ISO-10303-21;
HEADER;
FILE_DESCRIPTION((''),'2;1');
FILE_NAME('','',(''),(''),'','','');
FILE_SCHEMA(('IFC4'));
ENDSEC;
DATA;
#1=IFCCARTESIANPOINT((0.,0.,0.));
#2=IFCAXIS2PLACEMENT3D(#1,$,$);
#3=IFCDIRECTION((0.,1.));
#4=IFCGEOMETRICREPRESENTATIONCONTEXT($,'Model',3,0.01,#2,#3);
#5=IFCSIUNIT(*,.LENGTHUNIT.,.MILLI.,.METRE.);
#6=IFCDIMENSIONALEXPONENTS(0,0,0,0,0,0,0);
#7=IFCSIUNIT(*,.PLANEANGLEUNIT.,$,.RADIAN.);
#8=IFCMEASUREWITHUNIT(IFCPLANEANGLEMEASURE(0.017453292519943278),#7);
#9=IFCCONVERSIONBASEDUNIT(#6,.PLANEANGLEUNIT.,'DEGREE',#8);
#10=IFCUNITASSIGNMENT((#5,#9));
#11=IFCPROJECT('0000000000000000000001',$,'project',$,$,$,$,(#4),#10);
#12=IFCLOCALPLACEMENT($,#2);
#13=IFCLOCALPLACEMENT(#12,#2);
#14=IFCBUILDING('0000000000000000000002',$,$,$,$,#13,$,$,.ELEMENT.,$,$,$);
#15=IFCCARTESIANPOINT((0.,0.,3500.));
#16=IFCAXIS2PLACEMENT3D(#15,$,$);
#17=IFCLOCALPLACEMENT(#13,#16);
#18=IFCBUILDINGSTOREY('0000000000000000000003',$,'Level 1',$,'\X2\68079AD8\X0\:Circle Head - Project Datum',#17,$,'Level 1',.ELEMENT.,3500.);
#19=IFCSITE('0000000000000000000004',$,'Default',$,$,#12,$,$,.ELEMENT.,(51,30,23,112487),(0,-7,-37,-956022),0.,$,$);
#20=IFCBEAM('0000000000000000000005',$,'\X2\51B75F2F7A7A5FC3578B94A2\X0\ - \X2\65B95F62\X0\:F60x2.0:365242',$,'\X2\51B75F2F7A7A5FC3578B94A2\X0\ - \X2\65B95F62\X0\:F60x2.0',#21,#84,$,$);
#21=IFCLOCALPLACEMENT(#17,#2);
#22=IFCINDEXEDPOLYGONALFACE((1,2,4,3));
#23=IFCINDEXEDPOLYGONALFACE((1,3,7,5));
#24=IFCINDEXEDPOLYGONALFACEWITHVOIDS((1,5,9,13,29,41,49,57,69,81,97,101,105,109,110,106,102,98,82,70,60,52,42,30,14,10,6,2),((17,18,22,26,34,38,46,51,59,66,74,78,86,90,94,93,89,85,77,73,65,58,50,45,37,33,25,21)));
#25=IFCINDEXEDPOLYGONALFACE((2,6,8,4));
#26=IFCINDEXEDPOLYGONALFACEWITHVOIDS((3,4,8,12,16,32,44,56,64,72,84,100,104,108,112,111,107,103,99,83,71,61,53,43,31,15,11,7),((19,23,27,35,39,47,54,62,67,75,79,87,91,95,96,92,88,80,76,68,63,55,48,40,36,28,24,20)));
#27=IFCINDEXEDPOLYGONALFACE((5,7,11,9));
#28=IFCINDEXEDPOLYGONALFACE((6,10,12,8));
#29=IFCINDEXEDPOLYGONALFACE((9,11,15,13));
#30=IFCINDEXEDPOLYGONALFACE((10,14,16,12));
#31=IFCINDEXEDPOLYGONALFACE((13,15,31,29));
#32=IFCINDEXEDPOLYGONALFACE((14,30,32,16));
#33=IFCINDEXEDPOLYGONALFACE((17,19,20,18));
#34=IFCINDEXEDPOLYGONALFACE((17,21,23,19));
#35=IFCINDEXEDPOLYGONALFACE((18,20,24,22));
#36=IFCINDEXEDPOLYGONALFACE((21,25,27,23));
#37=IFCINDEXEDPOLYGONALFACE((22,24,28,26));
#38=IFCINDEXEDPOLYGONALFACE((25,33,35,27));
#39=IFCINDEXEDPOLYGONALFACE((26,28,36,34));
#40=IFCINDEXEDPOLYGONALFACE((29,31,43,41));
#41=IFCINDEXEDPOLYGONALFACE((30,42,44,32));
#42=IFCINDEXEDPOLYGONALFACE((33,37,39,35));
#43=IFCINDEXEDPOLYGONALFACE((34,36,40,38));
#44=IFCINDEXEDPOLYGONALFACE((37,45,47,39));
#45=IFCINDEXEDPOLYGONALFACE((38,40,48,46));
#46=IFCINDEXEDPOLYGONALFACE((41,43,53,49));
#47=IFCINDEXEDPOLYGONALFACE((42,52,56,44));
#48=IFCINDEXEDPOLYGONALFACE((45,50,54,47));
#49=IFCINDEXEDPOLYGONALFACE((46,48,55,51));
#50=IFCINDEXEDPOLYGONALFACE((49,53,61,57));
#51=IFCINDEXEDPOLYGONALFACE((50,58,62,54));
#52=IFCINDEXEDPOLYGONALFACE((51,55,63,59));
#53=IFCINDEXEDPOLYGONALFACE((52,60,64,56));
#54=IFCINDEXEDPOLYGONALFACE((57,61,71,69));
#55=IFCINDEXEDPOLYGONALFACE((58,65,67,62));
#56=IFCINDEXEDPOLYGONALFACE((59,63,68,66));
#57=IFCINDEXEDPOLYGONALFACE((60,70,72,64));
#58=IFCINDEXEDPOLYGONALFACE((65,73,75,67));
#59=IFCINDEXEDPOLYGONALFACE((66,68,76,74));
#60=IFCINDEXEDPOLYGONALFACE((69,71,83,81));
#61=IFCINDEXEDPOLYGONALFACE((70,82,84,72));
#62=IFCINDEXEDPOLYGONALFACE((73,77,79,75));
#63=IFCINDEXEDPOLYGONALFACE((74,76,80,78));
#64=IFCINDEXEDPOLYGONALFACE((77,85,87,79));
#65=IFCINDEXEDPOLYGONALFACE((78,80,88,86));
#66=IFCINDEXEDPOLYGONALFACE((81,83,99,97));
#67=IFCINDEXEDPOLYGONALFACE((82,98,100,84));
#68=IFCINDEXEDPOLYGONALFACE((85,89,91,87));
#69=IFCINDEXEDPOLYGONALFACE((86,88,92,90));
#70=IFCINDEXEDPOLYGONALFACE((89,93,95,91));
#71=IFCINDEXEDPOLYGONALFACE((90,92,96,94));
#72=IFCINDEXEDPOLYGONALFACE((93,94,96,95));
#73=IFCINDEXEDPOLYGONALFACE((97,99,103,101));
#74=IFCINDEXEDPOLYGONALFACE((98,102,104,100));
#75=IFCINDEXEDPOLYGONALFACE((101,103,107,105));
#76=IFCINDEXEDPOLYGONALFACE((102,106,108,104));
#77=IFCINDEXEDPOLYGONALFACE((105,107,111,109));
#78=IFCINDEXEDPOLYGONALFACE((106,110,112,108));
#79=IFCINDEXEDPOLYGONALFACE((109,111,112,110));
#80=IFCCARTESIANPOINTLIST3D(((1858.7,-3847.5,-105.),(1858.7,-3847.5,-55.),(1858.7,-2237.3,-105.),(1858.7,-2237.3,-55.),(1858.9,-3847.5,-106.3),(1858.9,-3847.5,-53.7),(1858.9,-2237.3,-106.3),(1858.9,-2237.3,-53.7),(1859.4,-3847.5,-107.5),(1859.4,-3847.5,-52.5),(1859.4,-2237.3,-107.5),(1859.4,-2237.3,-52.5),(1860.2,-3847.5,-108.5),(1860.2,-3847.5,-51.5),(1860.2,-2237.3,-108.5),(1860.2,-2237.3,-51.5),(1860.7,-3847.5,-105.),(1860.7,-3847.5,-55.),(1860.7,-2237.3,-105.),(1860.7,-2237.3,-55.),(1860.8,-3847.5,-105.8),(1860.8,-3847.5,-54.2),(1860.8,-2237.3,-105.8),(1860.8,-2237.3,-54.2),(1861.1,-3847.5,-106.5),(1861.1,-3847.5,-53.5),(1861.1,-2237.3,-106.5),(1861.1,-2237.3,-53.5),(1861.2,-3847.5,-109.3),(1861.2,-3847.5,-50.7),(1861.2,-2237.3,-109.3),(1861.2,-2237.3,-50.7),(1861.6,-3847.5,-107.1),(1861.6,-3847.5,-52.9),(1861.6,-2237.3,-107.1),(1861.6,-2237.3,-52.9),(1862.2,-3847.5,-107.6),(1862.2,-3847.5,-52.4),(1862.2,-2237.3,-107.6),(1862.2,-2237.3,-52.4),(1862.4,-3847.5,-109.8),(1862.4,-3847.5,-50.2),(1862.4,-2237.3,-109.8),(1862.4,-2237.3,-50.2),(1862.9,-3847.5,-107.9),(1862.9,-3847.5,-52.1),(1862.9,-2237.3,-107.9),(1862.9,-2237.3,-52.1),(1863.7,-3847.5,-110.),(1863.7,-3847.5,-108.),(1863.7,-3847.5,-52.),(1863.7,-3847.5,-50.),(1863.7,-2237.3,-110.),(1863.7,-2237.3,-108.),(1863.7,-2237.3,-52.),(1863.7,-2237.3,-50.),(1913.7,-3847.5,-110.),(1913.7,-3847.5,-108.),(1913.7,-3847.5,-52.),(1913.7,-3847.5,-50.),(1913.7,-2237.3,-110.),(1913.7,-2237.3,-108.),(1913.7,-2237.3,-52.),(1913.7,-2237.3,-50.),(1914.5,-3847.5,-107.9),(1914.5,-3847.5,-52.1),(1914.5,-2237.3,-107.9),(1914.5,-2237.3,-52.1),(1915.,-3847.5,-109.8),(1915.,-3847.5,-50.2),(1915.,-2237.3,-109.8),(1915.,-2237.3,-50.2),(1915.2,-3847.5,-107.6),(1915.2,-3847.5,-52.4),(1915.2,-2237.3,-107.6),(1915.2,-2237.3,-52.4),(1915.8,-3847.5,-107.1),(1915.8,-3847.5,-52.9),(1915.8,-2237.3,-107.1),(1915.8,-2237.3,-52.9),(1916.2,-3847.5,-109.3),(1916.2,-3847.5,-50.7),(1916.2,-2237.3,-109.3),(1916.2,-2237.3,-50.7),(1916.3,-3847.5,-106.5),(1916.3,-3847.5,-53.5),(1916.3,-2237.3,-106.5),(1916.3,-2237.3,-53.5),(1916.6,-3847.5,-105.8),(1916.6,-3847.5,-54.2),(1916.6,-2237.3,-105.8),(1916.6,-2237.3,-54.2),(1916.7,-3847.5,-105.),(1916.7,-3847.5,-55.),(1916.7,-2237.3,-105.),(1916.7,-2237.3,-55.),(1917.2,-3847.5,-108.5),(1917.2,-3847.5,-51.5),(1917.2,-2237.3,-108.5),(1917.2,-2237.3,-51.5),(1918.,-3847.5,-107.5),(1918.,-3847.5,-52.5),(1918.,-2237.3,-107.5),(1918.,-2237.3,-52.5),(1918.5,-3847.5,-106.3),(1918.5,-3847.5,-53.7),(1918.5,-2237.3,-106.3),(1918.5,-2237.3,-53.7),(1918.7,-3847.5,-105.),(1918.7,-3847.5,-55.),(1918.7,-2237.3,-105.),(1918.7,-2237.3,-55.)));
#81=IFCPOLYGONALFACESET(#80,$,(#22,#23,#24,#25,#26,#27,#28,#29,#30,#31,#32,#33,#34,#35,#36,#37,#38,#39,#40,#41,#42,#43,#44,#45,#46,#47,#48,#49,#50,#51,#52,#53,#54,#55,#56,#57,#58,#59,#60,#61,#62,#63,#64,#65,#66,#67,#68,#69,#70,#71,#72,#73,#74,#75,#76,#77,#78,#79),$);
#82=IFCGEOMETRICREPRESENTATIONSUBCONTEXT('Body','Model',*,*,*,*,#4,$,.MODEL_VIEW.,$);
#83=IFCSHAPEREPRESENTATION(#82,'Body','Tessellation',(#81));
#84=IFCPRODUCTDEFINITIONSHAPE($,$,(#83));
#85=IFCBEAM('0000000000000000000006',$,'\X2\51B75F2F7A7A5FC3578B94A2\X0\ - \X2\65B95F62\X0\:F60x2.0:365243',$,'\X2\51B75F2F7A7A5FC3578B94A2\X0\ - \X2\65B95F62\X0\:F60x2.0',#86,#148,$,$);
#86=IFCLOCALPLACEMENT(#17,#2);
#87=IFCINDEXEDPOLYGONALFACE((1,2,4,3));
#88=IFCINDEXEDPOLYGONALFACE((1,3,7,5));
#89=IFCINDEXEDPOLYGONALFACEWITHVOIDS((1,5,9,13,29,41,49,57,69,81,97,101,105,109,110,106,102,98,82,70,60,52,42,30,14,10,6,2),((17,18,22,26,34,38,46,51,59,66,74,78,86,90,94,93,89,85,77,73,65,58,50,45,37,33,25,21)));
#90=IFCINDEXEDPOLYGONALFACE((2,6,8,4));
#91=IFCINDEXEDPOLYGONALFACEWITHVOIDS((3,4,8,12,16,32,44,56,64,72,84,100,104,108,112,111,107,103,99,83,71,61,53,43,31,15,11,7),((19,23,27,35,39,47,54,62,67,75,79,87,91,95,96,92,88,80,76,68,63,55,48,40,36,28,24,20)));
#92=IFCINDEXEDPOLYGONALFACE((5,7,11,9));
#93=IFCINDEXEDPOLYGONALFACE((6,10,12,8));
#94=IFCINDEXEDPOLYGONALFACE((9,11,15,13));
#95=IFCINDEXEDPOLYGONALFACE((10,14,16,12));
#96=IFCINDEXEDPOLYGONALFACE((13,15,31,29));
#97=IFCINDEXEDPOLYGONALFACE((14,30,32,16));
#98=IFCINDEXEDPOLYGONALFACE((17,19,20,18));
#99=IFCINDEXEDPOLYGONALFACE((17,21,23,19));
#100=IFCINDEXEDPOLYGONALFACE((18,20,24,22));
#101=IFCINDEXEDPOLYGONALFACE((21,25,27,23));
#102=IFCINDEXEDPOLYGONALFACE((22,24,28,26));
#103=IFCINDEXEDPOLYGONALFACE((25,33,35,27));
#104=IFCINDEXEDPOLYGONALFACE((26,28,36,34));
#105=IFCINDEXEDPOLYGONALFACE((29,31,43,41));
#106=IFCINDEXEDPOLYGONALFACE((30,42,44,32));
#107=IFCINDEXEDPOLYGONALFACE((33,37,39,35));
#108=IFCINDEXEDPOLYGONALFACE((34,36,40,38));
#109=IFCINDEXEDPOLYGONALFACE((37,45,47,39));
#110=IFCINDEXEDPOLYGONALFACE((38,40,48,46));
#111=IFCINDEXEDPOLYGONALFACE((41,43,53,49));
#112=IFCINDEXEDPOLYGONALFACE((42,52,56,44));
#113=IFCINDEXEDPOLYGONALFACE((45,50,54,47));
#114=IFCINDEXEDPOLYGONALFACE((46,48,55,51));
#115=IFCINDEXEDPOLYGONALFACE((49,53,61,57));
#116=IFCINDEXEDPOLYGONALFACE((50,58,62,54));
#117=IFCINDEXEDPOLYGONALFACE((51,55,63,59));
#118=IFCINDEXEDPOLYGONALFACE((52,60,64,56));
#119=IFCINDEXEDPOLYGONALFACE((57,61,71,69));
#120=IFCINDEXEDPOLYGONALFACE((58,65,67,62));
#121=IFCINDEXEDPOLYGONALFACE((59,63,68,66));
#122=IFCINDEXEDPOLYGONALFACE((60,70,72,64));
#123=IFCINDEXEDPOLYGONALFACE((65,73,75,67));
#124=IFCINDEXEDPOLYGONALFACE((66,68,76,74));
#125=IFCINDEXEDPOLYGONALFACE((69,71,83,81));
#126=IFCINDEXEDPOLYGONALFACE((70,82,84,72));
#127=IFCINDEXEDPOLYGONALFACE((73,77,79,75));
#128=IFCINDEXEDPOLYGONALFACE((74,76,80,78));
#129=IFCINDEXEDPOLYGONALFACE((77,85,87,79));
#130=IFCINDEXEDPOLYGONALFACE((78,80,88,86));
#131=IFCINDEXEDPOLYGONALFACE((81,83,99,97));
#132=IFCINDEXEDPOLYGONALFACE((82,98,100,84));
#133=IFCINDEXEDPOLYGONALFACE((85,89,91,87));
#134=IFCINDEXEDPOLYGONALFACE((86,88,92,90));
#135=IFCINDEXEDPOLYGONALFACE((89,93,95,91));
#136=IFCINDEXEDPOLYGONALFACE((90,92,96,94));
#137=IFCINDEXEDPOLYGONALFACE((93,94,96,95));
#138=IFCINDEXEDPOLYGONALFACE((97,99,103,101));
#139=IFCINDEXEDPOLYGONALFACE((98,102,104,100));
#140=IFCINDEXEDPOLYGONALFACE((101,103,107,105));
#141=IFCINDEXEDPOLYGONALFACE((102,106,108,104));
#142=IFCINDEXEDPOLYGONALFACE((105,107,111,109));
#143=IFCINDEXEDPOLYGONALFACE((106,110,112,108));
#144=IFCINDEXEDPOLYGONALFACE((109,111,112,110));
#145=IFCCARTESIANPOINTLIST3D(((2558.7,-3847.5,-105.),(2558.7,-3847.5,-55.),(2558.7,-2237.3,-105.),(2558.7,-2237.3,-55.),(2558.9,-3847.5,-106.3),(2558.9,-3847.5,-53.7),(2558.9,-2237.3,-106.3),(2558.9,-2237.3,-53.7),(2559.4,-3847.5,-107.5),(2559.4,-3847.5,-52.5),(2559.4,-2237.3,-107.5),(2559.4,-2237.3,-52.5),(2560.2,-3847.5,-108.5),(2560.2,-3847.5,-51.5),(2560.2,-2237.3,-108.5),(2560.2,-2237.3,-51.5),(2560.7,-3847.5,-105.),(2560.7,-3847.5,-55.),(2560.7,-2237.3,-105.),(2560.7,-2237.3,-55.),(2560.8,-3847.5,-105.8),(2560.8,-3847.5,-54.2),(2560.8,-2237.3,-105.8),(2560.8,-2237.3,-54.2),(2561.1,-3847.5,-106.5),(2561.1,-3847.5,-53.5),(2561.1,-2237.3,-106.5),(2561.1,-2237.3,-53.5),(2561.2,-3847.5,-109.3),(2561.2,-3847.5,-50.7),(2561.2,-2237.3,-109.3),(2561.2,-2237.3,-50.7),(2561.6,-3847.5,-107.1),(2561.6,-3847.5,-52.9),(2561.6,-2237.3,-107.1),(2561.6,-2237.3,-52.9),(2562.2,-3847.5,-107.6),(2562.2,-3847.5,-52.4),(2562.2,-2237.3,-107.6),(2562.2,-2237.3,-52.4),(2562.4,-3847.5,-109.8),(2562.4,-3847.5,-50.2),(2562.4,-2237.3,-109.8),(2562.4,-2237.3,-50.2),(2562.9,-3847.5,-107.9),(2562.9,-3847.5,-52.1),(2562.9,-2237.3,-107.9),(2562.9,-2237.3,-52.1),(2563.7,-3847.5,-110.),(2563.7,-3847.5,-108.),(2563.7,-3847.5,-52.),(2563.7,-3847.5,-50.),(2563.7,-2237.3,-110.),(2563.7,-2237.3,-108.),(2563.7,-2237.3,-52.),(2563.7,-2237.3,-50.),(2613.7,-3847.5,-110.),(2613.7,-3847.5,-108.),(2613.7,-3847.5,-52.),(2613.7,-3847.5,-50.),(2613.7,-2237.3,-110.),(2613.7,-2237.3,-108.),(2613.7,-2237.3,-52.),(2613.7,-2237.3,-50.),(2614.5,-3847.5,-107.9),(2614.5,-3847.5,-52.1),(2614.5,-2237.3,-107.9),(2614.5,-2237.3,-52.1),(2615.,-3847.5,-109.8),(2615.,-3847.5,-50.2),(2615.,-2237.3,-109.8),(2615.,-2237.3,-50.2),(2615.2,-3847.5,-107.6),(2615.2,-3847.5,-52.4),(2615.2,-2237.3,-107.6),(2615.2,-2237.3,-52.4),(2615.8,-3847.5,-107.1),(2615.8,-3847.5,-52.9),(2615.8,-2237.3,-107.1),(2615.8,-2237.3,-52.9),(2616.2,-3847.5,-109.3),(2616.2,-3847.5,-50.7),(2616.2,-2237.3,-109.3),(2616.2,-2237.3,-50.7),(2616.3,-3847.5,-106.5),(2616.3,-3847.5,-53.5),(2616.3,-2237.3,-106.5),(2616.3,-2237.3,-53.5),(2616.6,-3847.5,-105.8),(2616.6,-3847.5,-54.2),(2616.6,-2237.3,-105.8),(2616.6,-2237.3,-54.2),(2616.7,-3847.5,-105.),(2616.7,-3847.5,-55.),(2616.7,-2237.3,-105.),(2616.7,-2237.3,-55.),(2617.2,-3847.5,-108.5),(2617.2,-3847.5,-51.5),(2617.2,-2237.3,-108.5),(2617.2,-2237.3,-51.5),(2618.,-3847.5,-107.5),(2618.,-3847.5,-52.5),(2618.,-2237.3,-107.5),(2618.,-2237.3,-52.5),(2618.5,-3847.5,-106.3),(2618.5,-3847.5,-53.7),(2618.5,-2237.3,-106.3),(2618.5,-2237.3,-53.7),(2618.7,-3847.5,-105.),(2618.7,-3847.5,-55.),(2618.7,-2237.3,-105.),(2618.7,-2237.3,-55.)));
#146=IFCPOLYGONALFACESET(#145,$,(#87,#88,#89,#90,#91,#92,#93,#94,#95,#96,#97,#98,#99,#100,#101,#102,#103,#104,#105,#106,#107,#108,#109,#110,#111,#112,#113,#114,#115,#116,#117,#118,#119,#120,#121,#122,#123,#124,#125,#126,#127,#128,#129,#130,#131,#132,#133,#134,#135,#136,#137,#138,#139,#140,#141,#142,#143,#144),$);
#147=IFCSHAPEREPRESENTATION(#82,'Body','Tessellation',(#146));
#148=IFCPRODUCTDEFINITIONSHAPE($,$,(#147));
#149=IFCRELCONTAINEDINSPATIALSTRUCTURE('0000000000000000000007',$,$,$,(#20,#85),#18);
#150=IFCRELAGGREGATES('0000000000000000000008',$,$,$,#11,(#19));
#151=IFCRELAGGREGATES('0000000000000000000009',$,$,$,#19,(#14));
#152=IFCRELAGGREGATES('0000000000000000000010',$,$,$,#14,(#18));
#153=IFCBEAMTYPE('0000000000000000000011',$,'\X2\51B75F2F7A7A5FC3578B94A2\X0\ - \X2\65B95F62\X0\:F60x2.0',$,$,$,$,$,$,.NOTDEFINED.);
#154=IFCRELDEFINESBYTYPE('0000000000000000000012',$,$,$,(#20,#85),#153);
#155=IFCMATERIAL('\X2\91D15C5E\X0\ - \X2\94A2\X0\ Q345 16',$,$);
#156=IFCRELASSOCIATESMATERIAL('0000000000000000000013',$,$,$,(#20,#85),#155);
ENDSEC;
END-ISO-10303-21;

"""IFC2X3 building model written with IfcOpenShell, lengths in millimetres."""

from ifc_helpers import new_model, entity, si_unit, converted_unit, direction, frame, frame_2d, origin, place, context, subcontext, project, spatial, polyline, circle_curve, parameter, trimmed, segment, composite_curve, outline, extrude, material, type_object, element, save


model = new_model("IFC2X3")

# Units and contexts
model_context = context("Model", 3, precision=0.01, world=origin(), true_north=direction((0.0, 1.0)))
body_context = subcontext(model_context, "Body", "Model", "MODEL_VIEW")
ifc_project = project(units=[si_unit("LENGTHUNIT", "METRE", prefix="MILLI"), converted_unit("PLANEANGLEUNIT", "DEGREE", entity("IfcPlaneAngleMeasure", 0.017453292519943278), si_unit("PLANEANGLEUNIT", "RADIAN"), dimensions=[0, 0, 0, 0, 0, 0, 0])], contexts=[model_context])

# Site, building, storey
site_placement = place(None, origin())
site = spatial("IfcSite", under=ifc_project, at=site_placement, Name="Default", CompositionType="ELEMENT", RefLatitude=(51, 30, 23, 112487), RefLongitude=(0, -7, -37, -956022), RefElevation=0.0)
building_placement = place(site_placement, origin())
building = spatial("IfcBuilding", under=site, at=building_placement, CompositionType="ELEMENT")
storey_placement = place(building_placement, frame((0.0, 0.0, 3500.0)))
storey = spatial("IfcBuildingStorey", under=building, at=storey_placement, Name="Level 1", ObjectType="标高:Circle Head - Project Datum", LongName="Level 1", CompositionType="ELEMENT", Elevation=3500.0)

# Beams
ifc_material_1 = material(Name="金属 - 钢 Q345 16")
beam_type_1 = type_object("IfcBeamType", Name="冷弯空心型钢 - 方形:F60x2.0", PredefinedType="NOTDEFINED")
beam_1_placement = place(storey_placement, frame((1888.7, -3815.6, -50.0), z_axis=(0.0, 0.0, 1.0), x_axis=(0.0, 1.0, 0.0)))
element("IfcBeam", 1, at=beam_1_placement, inside=storey, type_object=beam_type_1, material=ifc_material_1, Name="冷弯空心型钢 - 方形:F60x2.0:365242", ObjectType="冷弯空心型钢 - 方形:F60x2.0", context=body_context, shape_type="SweptSolid", body=[
    extrude(outline(composite_curve([segment(polyline([(-25.0, -30.0), (25.0, -30.0)]), True, "CONTINUOUS"), segment(trimmed(circle_curve(frame_2d((25.0, -25.0), x_axis=(1.0, 0.0)), 5.0), [parameter(270.0)], [parameter(360.0)], True, "PARAMETER"), True, "CONTINUOUS"), segment(polyline([(30.0, -25.0), (30.0, 25.0)]), True, "CONTINUOUS"), segment(trimmed(circle_curve(frame_2d((25.0, 25.0), x_axis=(1.0, 0.0)), 5.0), [parameter(360.0)], [parameter(90.0)], True, "PARAMETER"), True, "CONTINUOUS"), segment(polyline([(25.0, 30.0), (-25.0, 30.0)]), True, "CONTINUOUS"), segment(trimmed(circle_curve(frame_2d((-25.0, 25.0), x_axis=(1.0, 0.0)), 5.0), [parameter(90.0)], [parameter(180.0)], True, "PARAMETER"), True, "CONTINUOUS"), segment(polyline([(-30.0, 25.0), (-30.0, -25.0)]), True, "CONTINUOUS"), segment(trimmed(circle_curve(frame_2d((-25.0, -25.0), x_axis=(1.0, 0.0)), 5.0), [parameter(180.0)], [parameter(270.0)], True, "PARAMETER"), True, "CONTINUOUS")], self_intersect=False), holes=[composite_curve([segment(trimmed(circle_curve(frame_2d((-25.0, -25.0), x_axis=(1.0, 0.0)), 3.0), [parameter(180.0)], [parameter(270.0)], True, "PARAMETER"), False, "CONTINUOUS"), segment(polyline([(-28.0, -25.0), (-28.0, 25.0)]), True, "CONTINUOUS"), segment(trimmed(circle_curve(frame_2d((-25.0, 25.0), x_axis=(1.0, 0.0)), 3.0), [parameter(90.0)], [parameter(180.0)], True, "PARAMETER"), False, "CONTINUOUS"), segment(polyline([(-25.0, 28.0), (25.0, 28.0)]), True, "CONTINUOUS"), segment(trimmed(circle_curve(frame_2d((25.0, 25.0), x_axis=(1.0, 0.0)), 3.0), [parameter(0.0)], [parameter(90.0)], True, "PARAMETER"), False, "CONTINUOUS"), segment(polyline([(28.0, 25.0), (28.0, -25.0)]), True, "CONTINUOUS"), segment(trimmed(circle_curve(frame_2d((25.0, -25.0), x_axis=(1.0, 0.0)), 3.0), [parameter(270.0)], [parameter(360.0)], True, "PARAMETER"), False, "CONTINUOUS"), segment(polyline([(25.0, -28.0), (-25.0, -28.0)]), True, "CONTINUOUS")], self_intersect=False)]), frame((-31.9, 0.0, -30.0), z_axis=(1.0, 0.0, 0.0), x_axis=(0.0, -1.0, 0.0)), (0.0, 0.0, 1.0), 1610.2),
])
beam_2_placement = place(storey_placement, frame((2588.7, -3815.6, -50.0), z_axis=(0.0, 0.0, 1.0), x_axis=(0.0, 1.0, 0.0)))
element("IfcBeam", 2, at=beam_2_placement, inside=storey, type_object=beam_type_1, material=ifc_material_1, Name="冷弯空心型钢 - 方形:F60x2.0:365243", ObjectType="冷弯空心型钢 - 方形:F60x2.0", context=body_context, shape_type="SweptSolid", body=[
    extrude(outline(composite_curve([segment(polyline([(-25.0, -30.0), (25.0, -30.0)]), True, "CONTINUOUS"), segment(trimmed(circle_curve(frame_2d((25.0, -25.0), x_axis=(1.0, 0.0)), 5.0), [parameter(270.0)], [parameter(360.0)], True, "PARAMETER"), True, "CONTINUOUS"), segment(polyline([(30.0, -25.0), (30.0, 25.0)]), True, "CONTINUOUS"), segment(trimmed(circle_curve(frame_2d((25.0, 25.0), x_axis=(1.0, 0.0)), 5.0), [parameter(360.0)], [parameter(90.0)], True, "PARAMETER"), True, "CONTINUOUS"), segment(polyline([(25.0, 30.0), (-25.0, 30.0)]), True, "CONTINUOUS"), segment(trimmed(circle_curve(frame_2d((-25.0, 25.0), x_axis=(1.0, 0.0)), 5.0), [parameter(90.0)], [parameter(180.0)], True, "PARAMETER"), True, "CONTINUOUS"), segment(polyline([(-30.0, 25.0), (-30.0, -25.0)]), True, "CONTINUOUS"), segment(trimmed(circle_curve(frame_2d((-25.0, -25.0), x_axis=(1.0, 0.0)), 5.0), [parameter(180.0)], [parameter(270.0)], True, "PARAMETER"), True, "CONTINUOUS")], self_intersect=False), holes=[composite_curve([segment(trimmed(circle_curve(frame_2d((-25.0, -25.0), x_axis=(1.0, 0.0)), 3.0), [parameter(180.0)], [parameter(270.0)], True, "PARAMETER"), False, "CONTINUOUS"), segment(polyline([(-28.0, -25.0), (-28.0, 25.0)]), True, "CONTINUOUS"), segment(trimmed(circle_curve(frame_2d((-25.0, 25.0), x_axis=(1.0, 0.0)), 3.0), [parameter(90.0)], [parameter(180.0)], True, "PARAMETER"), False, "CONTINUOUS"), segment(polyline([(-25.0, 28.0), (25.0, 28.0)]), True, "CONTINUOUS"), segment(trimmed(circle_curve(frame_2d((25.0, 25.0), x_axis=(1.0, 0.0)), 3.0), [parameter(0.0)], [parameter(90.0)], True, "PARAMETER"), False, "CONTINUOUS"), segment(polyline([(28.0, 25.0), (28.0, -25.0)]), True, "CONTINUOUS"), segment(trimmed(circle_curve(frame_2d((25.0, -25.0), x_axis=(1.0, 0.0)), 3.0), [parameter(270.0)], [parameter(360.0)], True, "PARAMETER"), False, "CONTINUOUS"), segment(polyline([(25.0, -28.0), (-25.0, -28.0)]), True, "CONTINUOUS")], self_intersect=False)]), frame((-31.9, 0.0, -30.0), z_axis=(1.0, 0.0, 0.0), x_axis=(0.0, -1.0, 0.0)), (0.0, 0.0, 1.0), 1610.2),
])

save(model, "model.ifc")
